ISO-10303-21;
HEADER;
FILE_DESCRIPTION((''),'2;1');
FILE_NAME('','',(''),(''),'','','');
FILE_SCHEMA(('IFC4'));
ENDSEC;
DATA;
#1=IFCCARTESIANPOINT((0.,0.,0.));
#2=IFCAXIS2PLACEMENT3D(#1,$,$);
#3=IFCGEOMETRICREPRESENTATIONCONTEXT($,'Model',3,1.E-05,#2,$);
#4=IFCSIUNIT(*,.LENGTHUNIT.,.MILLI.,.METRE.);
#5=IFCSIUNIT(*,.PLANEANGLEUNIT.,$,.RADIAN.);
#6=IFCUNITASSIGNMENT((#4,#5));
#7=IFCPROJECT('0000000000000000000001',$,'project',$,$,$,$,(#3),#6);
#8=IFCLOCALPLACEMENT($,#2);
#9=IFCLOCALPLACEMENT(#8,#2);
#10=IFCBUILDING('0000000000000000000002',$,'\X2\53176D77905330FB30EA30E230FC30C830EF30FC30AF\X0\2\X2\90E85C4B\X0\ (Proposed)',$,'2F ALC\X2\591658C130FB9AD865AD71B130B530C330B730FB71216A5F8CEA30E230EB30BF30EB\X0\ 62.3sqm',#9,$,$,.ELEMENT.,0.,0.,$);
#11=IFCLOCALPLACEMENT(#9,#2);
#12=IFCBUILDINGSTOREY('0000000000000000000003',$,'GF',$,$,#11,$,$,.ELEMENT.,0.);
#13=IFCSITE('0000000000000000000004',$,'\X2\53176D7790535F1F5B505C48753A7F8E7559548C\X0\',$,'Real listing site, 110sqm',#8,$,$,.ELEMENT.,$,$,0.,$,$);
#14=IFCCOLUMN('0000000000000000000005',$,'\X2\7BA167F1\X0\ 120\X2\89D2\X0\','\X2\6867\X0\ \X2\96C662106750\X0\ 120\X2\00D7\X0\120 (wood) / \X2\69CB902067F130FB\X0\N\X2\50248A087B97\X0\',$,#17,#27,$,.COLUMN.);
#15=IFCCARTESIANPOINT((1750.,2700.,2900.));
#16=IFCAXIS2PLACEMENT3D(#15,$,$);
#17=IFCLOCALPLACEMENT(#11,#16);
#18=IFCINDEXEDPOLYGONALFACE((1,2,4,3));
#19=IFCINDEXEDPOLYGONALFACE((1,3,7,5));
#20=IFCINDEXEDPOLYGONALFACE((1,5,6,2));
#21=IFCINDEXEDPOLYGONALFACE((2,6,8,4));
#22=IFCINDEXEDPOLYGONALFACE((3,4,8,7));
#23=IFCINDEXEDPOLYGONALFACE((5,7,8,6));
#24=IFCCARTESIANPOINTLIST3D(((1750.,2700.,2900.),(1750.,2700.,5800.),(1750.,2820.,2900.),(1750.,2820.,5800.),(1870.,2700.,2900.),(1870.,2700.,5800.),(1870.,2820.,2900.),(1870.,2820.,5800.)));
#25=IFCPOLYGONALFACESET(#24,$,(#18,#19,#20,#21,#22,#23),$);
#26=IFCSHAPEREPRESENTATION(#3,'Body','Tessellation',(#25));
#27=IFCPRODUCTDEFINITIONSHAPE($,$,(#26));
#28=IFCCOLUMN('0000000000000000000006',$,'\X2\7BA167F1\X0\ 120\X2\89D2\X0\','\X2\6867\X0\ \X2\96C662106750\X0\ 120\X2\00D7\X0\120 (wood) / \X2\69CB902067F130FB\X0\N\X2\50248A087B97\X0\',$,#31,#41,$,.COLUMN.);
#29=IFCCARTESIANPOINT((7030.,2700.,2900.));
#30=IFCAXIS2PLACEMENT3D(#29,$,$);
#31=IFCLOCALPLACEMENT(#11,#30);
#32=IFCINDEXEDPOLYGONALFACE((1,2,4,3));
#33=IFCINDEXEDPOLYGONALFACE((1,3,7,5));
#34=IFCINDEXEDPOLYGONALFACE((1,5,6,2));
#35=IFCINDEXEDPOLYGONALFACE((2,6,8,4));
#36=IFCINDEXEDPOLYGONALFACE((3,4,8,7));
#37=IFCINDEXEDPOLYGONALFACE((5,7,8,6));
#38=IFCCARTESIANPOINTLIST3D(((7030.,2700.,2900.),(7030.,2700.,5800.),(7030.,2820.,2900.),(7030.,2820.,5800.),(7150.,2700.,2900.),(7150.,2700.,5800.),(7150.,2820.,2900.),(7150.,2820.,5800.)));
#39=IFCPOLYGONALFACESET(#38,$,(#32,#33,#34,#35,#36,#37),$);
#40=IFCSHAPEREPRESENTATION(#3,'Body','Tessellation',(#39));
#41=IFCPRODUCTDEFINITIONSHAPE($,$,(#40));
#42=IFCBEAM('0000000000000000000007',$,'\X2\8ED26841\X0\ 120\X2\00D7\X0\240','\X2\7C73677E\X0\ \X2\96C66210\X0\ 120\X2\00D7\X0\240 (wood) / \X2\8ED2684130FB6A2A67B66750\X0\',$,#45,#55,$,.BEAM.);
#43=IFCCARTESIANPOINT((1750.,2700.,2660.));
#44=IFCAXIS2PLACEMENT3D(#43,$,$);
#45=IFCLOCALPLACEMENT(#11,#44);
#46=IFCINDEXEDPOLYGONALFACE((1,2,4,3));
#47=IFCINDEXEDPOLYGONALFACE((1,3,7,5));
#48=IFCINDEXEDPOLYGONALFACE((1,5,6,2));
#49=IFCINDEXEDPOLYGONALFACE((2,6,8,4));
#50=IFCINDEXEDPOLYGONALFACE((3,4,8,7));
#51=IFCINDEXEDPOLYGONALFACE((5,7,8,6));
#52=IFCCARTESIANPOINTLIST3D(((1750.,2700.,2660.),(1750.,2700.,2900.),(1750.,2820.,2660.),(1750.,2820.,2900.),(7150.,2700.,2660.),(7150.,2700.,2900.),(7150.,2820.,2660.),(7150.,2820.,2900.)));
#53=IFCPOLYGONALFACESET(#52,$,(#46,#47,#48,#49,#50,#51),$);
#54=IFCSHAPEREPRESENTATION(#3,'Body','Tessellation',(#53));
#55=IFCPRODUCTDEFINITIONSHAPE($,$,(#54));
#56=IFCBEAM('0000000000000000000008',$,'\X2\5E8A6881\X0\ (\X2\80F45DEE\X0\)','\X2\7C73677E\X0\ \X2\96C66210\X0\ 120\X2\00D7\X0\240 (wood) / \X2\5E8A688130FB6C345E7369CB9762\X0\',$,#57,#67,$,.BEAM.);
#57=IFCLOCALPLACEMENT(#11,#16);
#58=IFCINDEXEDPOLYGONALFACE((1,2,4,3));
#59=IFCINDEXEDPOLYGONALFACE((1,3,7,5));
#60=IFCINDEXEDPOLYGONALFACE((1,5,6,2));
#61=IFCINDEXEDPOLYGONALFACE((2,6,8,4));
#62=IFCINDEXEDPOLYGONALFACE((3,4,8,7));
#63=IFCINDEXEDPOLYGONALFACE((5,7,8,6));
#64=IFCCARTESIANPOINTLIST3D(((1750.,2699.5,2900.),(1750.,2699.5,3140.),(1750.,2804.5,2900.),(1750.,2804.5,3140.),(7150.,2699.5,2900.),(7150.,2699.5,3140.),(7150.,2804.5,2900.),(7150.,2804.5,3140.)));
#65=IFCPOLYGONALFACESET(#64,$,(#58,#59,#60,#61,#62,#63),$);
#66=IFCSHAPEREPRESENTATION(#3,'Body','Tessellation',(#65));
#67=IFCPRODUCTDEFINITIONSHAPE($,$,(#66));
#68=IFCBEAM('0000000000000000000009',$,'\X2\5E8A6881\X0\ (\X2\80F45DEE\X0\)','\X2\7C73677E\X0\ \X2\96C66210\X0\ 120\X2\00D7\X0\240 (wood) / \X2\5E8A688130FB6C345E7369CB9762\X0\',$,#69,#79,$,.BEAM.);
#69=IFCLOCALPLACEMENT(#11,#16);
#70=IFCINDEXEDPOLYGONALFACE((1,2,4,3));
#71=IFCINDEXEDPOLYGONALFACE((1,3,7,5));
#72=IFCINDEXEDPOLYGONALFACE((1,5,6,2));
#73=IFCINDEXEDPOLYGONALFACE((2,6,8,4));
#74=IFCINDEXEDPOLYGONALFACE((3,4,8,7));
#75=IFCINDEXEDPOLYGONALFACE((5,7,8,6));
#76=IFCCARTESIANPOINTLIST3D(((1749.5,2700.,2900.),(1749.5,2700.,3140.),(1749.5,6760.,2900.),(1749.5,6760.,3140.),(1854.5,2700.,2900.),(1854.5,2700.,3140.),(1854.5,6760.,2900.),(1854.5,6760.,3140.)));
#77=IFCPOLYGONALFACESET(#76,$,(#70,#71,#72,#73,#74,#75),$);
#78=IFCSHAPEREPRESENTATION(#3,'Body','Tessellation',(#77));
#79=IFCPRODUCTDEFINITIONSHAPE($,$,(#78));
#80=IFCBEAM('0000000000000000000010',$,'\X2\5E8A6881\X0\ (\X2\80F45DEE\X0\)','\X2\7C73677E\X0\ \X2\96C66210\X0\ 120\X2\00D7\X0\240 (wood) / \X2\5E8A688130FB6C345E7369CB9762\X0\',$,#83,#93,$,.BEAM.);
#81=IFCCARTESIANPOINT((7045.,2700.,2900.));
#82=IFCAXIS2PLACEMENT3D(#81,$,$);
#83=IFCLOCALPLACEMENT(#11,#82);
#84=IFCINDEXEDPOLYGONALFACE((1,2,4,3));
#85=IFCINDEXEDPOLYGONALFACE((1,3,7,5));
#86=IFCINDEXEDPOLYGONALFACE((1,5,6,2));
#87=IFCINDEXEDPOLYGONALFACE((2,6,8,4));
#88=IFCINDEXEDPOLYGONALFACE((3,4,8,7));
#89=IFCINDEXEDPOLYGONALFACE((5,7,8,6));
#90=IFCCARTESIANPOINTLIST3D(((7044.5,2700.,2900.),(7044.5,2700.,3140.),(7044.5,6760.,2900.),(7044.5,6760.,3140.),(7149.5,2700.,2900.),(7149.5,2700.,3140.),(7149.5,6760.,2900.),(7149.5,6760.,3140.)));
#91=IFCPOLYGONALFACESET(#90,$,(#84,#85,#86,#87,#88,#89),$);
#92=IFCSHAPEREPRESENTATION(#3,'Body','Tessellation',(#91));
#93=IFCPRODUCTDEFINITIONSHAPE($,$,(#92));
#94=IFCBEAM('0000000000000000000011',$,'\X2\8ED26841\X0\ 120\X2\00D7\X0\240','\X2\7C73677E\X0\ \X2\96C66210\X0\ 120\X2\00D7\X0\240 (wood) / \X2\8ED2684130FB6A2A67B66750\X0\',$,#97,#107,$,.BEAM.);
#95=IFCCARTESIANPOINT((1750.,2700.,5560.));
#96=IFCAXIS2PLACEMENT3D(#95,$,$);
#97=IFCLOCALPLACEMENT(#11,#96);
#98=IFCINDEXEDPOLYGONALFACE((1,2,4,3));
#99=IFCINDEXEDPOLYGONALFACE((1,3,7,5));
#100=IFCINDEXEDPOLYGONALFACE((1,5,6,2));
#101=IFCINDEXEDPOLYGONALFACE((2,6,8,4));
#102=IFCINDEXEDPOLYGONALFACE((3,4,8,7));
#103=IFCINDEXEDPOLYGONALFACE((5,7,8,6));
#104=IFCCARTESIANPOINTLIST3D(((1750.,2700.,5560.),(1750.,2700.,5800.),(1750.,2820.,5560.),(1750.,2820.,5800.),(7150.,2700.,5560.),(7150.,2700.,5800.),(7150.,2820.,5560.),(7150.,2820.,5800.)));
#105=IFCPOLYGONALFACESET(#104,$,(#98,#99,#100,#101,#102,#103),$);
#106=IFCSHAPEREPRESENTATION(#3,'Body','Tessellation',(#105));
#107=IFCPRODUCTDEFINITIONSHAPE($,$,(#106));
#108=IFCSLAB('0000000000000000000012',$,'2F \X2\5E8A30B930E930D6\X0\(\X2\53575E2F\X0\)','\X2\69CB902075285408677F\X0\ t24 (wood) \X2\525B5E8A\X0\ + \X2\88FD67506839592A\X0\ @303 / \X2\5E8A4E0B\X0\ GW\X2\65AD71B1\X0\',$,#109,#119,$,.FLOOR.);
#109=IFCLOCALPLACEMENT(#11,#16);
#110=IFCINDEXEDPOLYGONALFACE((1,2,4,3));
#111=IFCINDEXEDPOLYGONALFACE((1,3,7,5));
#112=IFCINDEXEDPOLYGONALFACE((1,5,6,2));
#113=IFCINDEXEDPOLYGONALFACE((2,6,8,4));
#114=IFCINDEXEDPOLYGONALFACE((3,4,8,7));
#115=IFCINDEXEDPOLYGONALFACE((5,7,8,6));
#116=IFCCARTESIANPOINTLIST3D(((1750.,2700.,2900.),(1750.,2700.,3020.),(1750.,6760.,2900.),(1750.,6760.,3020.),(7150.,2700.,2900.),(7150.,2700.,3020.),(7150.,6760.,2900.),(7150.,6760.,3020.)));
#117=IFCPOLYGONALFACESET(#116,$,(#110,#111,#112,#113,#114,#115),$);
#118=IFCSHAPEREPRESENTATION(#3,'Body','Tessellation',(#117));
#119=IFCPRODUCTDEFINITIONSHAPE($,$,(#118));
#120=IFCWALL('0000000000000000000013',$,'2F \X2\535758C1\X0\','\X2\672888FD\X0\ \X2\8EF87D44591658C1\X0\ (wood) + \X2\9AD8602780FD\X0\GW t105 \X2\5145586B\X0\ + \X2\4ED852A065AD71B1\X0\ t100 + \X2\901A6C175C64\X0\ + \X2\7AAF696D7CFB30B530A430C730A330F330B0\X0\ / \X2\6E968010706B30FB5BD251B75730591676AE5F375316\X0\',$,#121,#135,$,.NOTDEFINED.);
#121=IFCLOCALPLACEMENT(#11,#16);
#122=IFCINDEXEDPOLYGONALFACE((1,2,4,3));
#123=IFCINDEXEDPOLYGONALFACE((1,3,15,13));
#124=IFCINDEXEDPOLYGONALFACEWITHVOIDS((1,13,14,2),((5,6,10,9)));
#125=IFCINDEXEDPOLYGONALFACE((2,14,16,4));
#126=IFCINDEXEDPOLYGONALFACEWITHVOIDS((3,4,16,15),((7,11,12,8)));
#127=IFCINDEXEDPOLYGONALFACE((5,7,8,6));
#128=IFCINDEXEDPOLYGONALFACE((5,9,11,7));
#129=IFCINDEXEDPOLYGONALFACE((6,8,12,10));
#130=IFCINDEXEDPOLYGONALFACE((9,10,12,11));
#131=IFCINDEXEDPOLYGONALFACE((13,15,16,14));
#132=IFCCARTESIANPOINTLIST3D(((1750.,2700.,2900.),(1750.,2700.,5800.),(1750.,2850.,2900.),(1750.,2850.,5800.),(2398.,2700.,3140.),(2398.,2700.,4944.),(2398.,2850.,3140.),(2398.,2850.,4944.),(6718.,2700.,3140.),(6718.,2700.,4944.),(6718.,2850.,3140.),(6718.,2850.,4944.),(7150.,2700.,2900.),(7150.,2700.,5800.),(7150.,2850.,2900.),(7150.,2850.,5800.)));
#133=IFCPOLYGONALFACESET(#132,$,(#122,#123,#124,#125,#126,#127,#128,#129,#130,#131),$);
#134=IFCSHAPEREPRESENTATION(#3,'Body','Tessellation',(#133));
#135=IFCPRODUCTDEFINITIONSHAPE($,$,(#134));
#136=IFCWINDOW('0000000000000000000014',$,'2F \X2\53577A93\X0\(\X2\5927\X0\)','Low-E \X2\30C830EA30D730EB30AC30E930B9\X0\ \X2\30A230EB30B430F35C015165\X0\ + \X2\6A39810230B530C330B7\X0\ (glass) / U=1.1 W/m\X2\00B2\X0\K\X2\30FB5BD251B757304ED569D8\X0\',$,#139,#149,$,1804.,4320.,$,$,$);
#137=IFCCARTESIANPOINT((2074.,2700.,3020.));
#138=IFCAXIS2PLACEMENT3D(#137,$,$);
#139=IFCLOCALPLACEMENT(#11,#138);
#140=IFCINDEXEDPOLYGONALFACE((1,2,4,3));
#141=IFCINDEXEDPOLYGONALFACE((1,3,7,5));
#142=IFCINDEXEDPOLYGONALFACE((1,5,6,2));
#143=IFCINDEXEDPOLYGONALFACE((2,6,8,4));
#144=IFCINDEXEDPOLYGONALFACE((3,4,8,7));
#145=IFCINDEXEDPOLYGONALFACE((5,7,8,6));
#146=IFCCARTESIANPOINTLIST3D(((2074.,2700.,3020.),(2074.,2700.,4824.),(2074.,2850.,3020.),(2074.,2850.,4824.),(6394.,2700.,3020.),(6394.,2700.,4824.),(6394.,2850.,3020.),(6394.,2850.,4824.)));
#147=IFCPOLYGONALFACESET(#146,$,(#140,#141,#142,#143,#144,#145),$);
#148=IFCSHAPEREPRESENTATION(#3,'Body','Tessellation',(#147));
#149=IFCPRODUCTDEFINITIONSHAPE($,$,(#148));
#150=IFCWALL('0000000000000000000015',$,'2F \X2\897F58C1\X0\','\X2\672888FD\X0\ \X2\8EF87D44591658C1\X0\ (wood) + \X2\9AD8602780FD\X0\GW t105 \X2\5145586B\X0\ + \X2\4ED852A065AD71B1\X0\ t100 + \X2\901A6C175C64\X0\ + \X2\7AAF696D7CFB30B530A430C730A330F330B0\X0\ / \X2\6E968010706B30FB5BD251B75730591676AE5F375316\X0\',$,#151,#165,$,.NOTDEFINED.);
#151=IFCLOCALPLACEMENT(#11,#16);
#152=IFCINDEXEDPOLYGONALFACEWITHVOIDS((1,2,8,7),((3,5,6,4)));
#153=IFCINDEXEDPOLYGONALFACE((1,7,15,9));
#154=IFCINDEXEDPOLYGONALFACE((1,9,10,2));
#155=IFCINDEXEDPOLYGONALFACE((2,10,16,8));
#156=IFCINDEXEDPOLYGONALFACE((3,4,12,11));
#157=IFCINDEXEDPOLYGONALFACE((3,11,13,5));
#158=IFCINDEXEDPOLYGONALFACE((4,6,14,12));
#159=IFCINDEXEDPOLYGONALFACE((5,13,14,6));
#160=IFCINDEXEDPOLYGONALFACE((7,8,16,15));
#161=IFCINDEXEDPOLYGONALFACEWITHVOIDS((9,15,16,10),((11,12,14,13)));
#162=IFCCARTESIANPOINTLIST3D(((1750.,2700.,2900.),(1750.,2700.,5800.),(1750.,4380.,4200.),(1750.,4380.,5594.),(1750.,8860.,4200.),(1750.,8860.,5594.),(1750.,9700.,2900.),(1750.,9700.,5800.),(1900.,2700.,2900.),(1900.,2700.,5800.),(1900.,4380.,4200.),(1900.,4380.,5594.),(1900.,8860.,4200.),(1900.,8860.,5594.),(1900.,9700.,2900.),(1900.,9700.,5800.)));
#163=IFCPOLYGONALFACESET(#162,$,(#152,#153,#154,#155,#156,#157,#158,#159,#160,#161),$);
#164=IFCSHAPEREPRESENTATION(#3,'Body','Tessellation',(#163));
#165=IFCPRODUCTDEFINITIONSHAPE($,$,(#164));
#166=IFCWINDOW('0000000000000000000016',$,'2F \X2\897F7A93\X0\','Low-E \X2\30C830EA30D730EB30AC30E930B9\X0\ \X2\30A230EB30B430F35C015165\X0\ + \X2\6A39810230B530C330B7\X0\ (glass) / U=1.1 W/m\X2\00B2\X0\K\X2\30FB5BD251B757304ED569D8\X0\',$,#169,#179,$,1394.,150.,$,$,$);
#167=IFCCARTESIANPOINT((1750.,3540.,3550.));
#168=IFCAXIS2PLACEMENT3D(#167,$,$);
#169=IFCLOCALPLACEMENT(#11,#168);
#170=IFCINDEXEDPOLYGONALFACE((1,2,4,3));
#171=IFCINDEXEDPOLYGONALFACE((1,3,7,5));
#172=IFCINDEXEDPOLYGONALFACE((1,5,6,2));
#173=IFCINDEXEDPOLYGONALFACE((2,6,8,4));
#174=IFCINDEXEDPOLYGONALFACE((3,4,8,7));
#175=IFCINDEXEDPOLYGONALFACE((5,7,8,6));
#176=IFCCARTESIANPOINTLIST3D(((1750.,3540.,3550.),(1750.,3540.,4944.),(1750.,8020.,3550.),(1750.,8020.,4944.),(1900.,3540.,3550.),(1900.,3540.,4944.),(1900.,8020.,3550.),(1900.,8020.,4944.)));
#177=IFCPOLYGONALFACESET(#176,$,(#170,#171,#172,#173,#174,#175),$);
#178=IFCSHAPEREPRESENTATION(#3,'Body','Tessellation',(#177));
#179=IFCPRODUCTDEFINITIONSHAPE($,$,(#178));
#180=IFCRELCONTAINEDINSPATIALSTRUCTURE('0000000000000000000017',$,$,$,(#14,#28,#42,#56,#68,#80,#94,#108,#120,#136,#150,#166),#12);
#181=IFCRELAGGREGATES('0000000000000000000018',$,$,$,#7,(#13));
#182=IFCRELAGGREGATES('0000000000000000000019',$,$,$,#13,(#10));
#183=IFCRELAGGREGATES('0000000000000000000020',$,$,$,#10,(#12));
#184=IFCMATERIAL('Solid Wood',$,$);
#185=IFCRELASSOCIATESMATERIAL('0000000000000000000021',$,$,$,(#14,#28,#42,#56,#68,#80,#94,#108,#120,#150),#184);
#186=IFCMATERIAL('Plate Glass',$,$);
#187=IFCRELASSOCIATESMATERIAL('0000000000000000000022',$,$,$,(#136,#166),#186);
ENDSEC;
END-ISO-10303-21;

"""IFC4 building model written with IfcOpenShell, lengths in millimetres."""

from ifc_helpers import new_model, si_unit, frame, frame_2d, origin, place, context, project, spatial, rectangle, extrude, material, element, fill, save


model = new_model("IFC4")

# Units and contexts
model_context = context("Model", 3, precision=1e-05, world=origin())
ifc_project = project(units=[si_unit("LENGTHUNIT", "METRE", prefix="MILLI"), si_unit("PLANEANGLEUNIT", "RADIAN")], contexts=[model_context])

# Site, building, storey
site_placement = place(None, origin())
site = spatial("IfcSite", under=ifc_project, at=site_placement, Name="北海道弟子屈町美留和", ObjectType="Real listing site, 110sqm", CompositionType="ELEMENT", RefElevation=0.0)
building_placement = place(site_placement, origin())
building = spatial("IfcBuilding", under=site, at=building_placement, Name="北海道・リモートワーク2部屋 (Proposed)", ObjectType="2F ALC外壁・高断熱サッシ・無機質モルタル 62.3sqm", CompositionType="ELEMENT", ElevationOfRefHeight=0.0, ElevationOfTerrain=0.0)
storey_placement = place(building_placement, origin())
storey = spatial("IfcBuildingStorey", under=building, at=storey_placement, Name="GF", CompositionType="ELEMENT", Elevation=0.0)

# Columns
ifc_material_1 = material(Name="Solid Wood")
column_1_placement = place(storey_placement, frame((1750.0, 2700.0, 2900.0)))
element("IfcColumn", 1, at=column_1_placement, inside=storey, material=ifc_material_1, Name="管柱 120角", Description="桧 集成材 120×120 (wood) / 構造柱・N値計算", PredefinedType="COLUMN", context=model_context, shape_type="SweptSolid", body=[
    extrude(rectangle(XDim=120.0, YDim=120.0, at=frame_2d((60.0, 60.0))), frame((1750.0, 2700.0, 2900.0)), (0.0, 0.0, 1.0), 2900.0),
])
column_2_placement = place(storey_placement, frame((7030.0, 2700.0, 2900.0)))
element("IfcColumn", 2, at=column_2_placement, inside=storey, material=ifc_material_1, Name="管柱 120角", Description="桧 集成材 120×120 (wood) / 構造柱・N値計算", PredefinedType="COLUMN", context=model_context, shape_type="SweptSolid", body=[
    extrude(rectangle(XDim=120.0, YDim=120.0, at=frame_2d((60.0, 60.0))), frame((7030.0, 2700.0, 2900.0)), (0.0, 0.0, 1.0), 2900.0),
])

# Beams
beam_1_placement = place(storey_placement, frame((1750.0, 2700.0, 2660.0)))
element("IfcBeam", 3, at=beam_1_placement, inside=storey, material=ifc_material_1, Name="軒桁 120×240", Description="米松 集成 120×240 (wood) / 軒桁・横架材", PredefinedType="BEAM", context=model_context, shape_type="SweptSolid", body=[
    extrude(rectangle(XDim=5400.0, YDim=120.0, at=frame_2d((2700.0, 60.0))), frame((1750.0, 2700.0, 2660.0)), (0.0, 0.0, 1.0), 240.0),
])
beam_2_placement = place(storey_placement, frame((1750.0, 2700.0, 2900.0)))
element("IfcBeam", 4, at=beam_2_placement, inside=storey, material=ifc_material_1, Name="床梁 (胴差)", Description="米松 集成 120×240 (wood) / 床梁・水平構面", PredefinedType="BEAM", context=model_context, shape_type="SweptSolid", body=[
    extrude(rectangle(XDim=5400.0, YDim=105.0, at=frame_2d((2700.0, 52.0))), frame((1750.0, 2700.0, 2900.0)), (0.0, 0.0, 1.0), 240.0),
])
beam_3_placement = place(storey_placement, frame((1750.0, 2700.0, 2900.0)))
element("IfcBeam", 5, at=beam_3_placement, inside=storey, material=ifc_material_1, Name="床梁 (胴差)", Description="米松 集成 120×240 (wood) / 床梁・水平構面", PredefinedType="BEAM", context=model_context, shape_type="SweptSolid", body=[
    extrude(rectangle(XDim=105.0, YDim=4060.0, at=frame_2d((52.0, 2030.0))), frame((1750.0, 2700.0, 2900.0)), (0.0, 0.0, 1.0), 240.0),
])
beam_4_placement = place(storey_placement, frame((7045.0, 2700.0, 2900.0)))
element("IfcBeam", 6, at=beam_4_placement, inside=storey, material=ifc_material_1, Name="床梁 (胴差)", Description="米松 集成 120×240 (wood) / 床梁・水平構面", PredefinedType="BEAM", context=model_context, shape_type="SweptSolid", body=[
    extrude(rectangle(XDim=105.0, YDim=4060.0, at=frame_2d((52.0, 2030.0))), frame((7045.0, 2700.0, 2900.0)), (0.0, 0.0, 1.0), 240.0),
])
beam_5_placement = place(storey_placement, frame((1750.0, 2700.0, 5560.0)))
element("IfcBeam", 7, at=beam_5_placement, inside=storey, material=ifc_material_1, Name="軒桁 120×240", Description="米松 集成 120×240 (wood) / 軒桁・横架材", PredefinedType="BEAM", context=model_context, shape_type="SweptSolid", body=[
    extrude(rectangle(XDim=5400.0, YDim=120.0, at=frame_2d((2700.0, 60.0))), frame((1750.0, 2700.0, 5560.0)), (0.0, 0.0, 1.0), 240.0),
])

# Slab
slab_placement = place(storey_placement, frame((1750.0, 2700.0, 2900.0)))
element("IfcSlab", 8, at=slab_placement, inside=storey, material=ifc_material_1, Name="2F 床スラブ(南帯)", Description="構造用合板 t24 (wood) 剛床 + 製材根太 @303 / 床下 GW断熱", PredefinedType="FLOOR", context=model_context, shape_type="SweptSolid", body=[
    extrude(rectangle(XDim=5400.0, YDim=4060.0, at=frame_2d((2700.0, 2030.0))), frame((1750.0, 2700.0, 2900.0)), (0.0, 0.0, 1.0), 120.0),
])

# Walls, openings, windows
wall_1_placement = place(storey_placement, frame((1750.0, 2700.0, 2900.0)))
wall_1 = element("IfcWall", 9, at=wall_1_placement, inside=storey, material=ifc_material_1, Name="2F 南壁", Description="木製 軸組外壁 (wood) + 高性能GW t105 充填 + 付加断熱 t100 + 通気層 + 窯業系サイディング / 準耐火・寒冷地外皮強化", PredefinedType="NOTDEFINED", context=model_context, shape_type="SweptSolid", body=[
    extrude(rectangle(XDim=5400.0, YDim=150.0, at=frame_2d((2700.0, 75.0))), frame((1750.0, 2700.0, 2900.0)), (0.0, 0.0, 1.0), 2900.0),
])
opening_1_placement = place(storey_placement, frame((2074.0, 2700.0, 3020.0)))
opening_1 = element("IfcOpeningElement", 10, at=opening_1_placement, cuts=wall_1, PredefinedType="NOTDEFINED", context=model_context, shape_type="SweptSolid", body=[
    extrude(rectangle(XDim=4320.0, YDim=150.0, at=frame_2d((2160.0, 75.0))), frame((2074.0, 2700.0, 3020.0)), (0.0, 0.0, 1.0), 1804.0),
])
ifc_material_2 = material(Name="Plate Glass")
window_1_placement = place(storey_placement, frame((2074.0, 2700.0, 3020.0)))
window_1 = element("IfcWindow", 11, at=window_1_placement, inside=storey, material=ifc_material_2, Name="2F 南窓(大)", Description="Low-E トリプルガラス アルゴン封入 + 樹脂サッシ (glass) / U=1.1 W/m²K・寒冷地仕様", OverallHeight=1804.0, OverallWidth=4320.0, context=model_context, shape_type="SweptSolid", body=[
    extrude(rectangle(XDim=4320.0, YDim=150.0, at=frame_2d((2160.0, 75.0))), frame((2074.0, 2700.0, 3020.0)), (0.0, 0.0, 1.0), 1804.0),
])
fill(opening_1, window_1)
wall_2_placement = place(storey_placement, frame((1750.0, 2700.0, 2900.0)))
wall_2 = element("IfcWall", 12, at=wall_2_placement, inside=storey, material=ifc_material_1, Name="2F 西壁", Description="木製 軸組外壁 (wood) + 高性能GW t105 充填 + 付加断熱 t100 + 通気層 + 窯業系サイディング / 準耐火・寒冷地外皮強化", PredefinedType="NOTDEFINED", context=model_context, shape_type="SweptSolid", body=[
    extrude(rectangle(XDim=150.0, YDim=7000.0, at=frame_2d((75.0, 3500.0))), frame((1750.0, 2700.0, 2900.0)), (0.0, 0.0, 1.0), 2900.0),
])
opening_2_placement = place(storey_placement, frame((1750.0, 3540.0, 3550.0)))
opening_2 = element("IfcOpeningElement", 13, at=opening_2_placement, cuts=wall_2, PredefinedType="NOTDEFINED", context=model_context, shape_type="SweptSolid", body=[
    extrude(rectangle(XDim=150.0, YDim=4480.0, at=frame_2d((75.0, 2240.0))), frame((1750.0, 3540.0, 3550.0)), (0.0, 0.0, 1.0), 1394.0),
])
window_2_placement = place(storey_placement, frame((1750.0, 3540.0, 3550.0)))
window_2 = element("IfcWindow", 14, at=window_2_placement, inside=storey, material=ifc_material_2, Name="2F 西窓", Description="Low-E トリプルガラス アルゴン封入 + 樹脂サッシ (glass) / U=1.1 W/m²K・寒冷地仕様", OverallHeight=1394.0, OverallWidth=150.0, context=model_context, shape_type="SweptSolid", body=[
    extrude(rectangle(XDim=150.0, YDim=4480.0, at=frame_2d((75.0, 2240.0))), frame((1750.0, 3540.0, 3550.0)), (0.0, 0.0, 1.0), 1394.0),
])
fill(opening_2, window_2)

save(model, "model.ifc")
